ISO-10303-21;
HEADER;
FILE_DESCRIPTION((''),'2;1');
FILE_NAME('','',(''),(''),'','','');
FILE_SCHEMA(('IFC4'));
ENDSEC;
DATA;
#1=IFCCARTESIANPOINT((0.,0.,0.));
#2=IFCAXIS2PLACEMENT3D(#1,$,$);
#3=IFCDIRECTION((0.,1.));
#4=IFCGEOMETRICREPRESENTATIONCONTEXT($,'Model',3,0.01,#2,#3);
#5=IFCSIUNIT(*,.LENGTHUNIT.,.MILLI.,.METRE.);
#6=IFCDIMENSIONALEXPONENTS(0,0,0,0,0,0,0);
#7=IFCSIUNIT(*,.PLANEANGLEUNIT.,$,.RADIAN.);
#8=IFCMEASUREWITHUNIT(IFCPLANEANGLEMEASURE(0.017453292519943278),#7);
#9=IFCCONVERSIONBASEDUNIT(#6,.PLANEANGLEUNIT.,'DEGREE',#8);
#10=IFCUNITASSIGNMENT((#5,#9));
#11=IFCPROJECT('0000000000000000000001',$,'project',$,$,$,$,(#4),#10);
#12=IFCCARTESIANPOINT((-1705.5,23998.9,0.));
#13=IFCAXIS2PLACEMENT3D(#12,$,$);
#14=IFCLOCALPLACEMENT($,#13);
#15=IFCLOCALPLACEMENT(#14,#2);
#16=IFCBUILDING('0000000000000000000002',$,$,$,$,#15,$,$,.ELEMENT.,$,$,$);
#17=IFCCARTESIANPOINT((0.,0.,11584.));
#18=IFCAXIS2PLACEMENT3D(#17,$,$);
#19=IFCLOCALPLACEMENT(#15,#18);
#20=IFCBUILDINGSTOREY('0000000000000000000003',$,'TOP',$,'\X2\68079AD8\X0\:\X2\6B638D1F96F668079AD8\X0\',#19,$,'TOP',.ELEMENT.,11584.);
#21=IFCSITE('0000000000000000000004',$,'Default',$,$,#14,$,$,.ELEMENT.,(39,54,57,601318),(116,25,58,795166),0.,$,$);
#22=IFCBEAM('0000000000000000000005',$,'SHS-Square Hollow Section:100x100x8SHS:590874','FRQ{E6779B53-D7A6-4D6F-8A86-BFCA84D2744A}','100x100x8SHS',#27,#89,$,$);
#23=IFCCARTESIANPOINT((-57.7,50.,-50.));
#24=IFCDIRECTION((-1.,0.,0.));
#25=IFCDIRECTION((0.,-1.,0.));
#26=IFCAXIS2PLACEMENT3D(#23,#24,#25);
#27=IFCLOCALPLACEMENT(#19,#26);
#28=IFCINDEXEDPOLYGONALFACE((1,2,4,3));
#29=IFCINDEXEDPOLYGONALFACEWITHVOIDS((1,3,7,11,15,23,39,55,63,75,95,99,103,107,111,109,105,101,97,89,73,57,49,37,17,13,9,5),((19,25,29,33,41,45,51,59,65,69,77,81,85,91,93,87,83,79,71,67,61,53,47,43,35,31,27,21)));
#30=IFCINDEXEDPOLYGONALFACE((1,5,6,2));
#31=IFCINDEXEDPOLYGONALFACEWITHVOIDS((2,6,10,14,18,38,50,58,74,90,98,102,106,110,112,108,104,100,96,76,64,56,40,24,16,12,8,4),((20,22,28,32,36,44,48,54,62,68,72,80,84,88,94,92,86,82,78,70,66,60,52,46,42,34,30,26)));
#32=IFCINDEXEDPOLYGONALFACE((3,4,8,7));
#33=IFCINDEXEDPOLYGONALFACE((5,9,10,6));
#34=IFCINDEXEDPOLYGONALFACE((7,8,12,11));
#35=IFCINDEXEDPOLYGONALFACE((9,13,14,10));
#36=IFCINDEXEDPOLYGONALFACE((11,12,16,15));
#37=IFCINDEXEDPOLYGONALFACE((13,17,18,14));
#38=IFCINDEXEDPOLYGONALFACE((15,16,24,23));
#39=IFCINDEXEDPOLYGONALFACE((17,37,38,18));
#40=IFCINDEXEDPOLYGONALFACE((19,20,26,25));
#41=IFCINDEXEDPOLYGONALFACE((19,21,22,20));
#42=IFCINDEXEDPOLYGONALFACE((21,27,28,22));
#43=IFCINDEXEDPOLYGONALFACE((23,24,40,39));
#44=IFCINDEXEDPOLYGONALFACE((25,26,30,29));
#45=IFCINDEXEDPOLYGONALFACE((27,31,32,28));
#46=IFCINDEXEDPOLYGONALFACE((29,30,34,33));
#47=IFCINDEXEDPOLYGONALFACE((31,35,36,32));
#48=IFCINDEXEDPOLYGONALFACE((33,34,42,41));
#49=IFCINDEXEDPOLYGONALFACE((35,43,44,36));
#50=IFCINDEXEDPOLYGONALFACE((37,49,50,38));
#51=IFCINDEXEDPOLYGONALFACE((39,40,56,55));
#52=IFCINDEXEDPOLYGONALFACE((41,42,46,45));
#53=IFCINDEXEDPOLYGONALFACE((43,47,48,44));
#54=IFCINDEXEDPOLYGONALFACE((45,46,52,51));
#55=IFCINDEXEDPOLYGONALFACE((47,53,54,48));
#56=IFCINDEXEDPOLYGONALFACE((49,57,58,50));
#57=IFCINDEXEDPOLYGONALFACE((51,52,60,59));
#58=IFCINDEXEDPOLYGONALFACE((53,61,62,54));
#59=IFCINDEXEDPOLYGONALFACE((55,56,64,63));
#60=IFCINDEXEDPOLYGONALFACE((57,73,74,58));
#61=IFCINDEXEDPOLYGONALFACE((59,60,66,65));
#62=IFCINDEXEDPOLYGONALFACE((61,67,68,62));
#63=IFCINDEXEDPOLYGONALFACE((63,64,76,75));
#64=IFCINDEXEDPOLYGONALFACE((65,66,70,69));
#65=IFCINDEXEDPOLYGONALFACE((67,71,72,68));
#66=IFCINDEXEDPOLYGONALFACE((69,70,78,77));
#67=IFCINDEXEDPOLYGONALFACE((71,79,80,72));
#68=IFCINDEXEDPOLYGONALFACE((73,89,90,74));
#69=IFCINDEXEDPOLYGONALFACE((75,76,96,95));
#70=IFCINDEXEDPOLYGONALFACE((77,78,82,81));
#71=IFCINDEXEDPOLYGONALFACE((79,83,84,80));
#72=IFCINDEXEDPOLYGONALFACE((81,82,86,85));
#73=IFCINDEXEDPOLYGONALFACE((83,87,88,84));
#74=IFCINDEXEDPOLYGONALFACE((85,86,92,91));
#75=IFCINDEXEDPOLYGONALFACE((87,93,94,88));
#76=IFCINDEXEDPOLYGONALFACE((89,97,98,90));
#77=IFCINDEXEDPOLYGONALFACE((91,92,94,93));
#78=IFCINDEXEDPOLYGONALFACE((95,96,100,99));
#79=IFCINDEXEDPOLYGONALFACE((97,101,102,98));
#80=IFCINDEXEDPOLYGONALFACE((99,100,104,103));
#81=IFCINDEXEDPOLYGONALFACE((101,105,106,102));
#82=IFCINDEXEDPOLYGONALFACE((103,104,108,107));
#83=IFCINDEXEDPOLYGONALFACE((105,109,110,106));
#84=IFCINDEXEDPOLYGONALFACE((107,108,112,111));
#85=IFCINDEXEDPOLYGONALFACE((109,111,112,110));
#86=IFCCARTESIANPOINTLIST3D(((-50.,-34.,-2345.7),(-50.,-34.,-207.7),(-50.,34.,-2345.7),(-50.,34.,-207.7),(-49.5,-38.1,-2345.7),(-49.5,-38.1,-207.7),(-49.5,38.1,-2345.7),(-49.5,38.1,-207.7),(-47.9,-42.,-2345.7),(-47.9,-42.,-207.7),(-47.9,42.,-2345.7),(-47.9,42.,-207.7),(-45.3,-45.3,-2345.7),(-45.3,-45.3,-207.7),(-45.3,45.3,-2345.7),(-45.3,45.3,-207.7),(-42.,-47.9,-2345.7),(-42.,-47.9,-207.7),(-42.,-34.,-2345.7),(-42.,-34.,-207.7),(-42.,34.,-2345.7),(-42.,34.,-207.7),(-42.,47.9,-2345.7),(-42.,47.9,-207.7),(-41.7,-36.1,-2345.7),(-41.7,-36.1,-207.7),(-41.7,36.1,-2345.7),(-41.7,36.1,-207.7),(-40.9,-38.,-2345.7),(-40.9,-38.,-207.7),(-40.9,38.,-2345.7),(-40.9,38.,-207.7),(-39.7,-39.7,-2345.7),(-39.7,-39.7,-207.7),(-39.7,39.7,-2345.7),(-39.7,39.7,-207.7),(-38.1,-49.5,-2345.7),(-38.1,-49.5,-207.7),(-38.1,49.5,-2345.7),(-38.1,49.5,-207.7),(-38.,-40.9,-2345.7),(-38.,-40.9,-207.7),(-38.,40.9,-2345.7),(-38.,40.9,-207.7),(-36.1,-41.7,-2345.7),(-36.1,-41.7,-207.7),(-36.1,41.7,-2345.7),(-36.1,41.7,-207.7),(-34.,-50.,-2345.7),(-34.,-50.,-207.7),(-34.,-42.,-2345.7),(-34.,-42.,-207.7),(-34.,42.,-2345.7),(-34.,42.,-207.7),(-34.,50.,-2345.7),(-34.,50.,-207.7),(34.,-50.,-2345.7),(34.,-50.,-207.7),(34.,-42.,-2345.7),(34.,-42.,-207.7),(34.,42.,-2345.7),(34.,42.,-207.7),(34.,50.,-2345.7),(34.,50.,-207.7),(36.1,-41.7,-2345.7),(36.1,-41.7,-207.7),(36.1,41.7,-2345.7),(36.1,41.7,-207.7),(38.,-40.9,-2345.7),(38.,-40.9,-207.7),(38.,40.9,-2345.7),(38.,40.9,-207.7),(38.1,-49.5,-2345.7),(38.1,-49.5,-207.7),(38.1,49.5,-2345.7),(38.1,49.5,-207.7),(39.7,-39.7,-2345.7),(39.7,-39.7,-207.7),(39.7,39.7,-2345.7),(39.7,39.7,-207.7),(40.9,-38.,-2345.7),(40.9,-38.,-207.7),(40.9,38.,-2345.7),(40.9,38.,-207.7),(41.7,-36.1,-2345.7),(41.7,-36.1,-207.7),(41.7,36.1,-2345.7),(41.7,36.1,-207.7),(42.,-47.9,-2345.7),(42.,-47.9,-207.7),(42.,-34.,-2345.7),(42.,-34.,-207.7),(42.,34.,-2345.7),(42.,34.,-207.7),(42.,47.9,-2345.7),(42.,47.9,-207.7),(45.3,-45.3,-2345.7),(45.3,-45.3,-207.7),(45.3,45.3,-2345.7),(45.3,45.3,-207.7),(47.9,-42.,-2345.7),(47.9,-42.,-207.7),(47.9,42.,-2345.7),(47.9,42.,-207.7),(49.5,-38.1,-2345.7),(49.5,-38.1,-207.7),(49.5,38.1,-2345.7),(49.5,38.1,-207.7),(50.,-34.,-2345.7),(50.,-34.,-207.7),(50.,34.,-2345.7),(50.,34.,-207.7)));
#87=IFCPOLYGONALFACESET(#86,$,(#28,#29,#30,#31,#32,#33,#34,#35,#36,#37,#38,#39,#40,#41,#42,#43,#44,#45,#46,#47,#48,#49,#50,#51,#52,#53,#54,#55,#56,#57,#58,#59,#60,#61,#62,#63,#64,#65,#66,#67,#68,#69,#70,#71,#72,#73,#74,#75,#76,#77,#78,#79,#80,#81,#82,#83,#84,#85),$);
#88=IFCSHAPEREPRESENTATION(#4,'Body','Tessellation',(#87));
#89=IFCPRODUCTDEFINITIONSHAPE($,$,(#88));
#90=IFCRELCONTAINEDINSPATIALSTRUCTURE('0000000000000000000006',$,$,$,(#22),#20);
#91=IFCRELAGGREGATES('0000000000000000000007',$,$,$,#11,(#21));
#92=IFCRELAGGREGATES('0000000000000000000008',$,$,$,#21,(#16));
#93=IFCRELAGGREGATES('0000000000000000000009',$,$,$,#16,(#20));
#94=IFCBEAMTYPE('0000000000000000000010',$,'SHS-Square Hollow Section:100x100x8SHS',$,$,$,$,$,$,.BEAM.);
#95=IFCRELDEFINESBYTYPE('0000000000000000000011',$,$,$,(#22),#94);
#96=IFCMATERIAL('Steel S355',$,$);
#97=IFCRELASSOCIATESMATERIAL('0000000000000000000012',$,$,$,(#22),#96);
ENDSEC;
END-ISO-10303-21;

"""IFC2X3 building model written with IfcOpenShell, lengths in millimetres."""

from ifc_helpers import new_model, entity, si_unit, converted_unit, direction, frame, origin, origin_2d, place, context, project, spatial, hollow_rectangle, extrude, clip, halfspace, material, type_object, element, save


model = new_model("IFC2X3")

# Units and contexts
model_context = context("Model", 3, precision=0.01, world=origin(), true_north=direction((0.0, 1.0)))
ifc_project = project(units=[si_unit("LENGTHUNIT", "METRE", prefix="MILLI"), converted_unit("PLANEANGLEUNIT", "DEGREE", entity("IfcPlaneAngleMeasure", 0.017453292519943278), si_unit("PLANEANGLEUNIT", "RADIAN"), dimensions=[0, 0, 0, 0, 0, 0, 0])], contexts=[model_context])

# Site, building, storey
site_placement = place(None, frame((-1705.5, 23998.9, 0.0)))
site = spatial("IfcSite", under=ifc_project, at=site_placement, Name="Default", CompositionType="ELEMENT", RefLatitude=(39, 54, 57, 601318), RefLongitude=(116, 25, 58, 795166), RefElevation=0.0)
building_placement = place(site_placement, origin())
building = spatial("IfcBuilding", under=site, at=building_placement, CompositionType="ELEMENT")
storey_placement = place(building_placement, frame((0.0, 0.0, 11584.0)))
storey = spatial("IfcBuildingStorey", under=building, at=storey_placement, Name="TOP", ObjectType="标高:正负零标高", LongName="TOP", CompositionType="ELEMENT", Elevation=11584.0)

# Shared definitions
ifc_material_1 = material(Name="Steel S355")

# Beam
beam_type_1 = type_object("IfcBeamType", Name="SHS-Square Hollow Section:100x100x8SHS", PredefinedType="BEAM")
beam_1_placement = place(storey_placement, frame((-57.7, 50.0, -50.0), z_axis=(-1.0, 0.0, 0.0), x_axis=(0.0, -1.0, 0.0)))
element("IfcBeam", 1, at=beam_1_placement, inside=storey, type_object=beam_type_1, material=ifc_material_1, Name="SHS-Square Hollow Section:100x100x8SHS:590874", Description="FRQ{E6779B53-D7A6-4D6F-8A86-BFCA84D2744A}", ObjectType="100x100x8SHS", context=model_context, shape_type="Clipping", body=[
    clip(clip(extrude(hollow_rectangle(XDim=100.0, YDim=100.0, WallThickness=8.0, InnerFilletRadius=8.0, OuterFilletRadius=16.0, at=origin_2d()), origin(), (0.0, 0.0, -1.0), 2551.4), halfspace(frame((50.0, -11534.0, -207.7), z_axis=(0.0, 0.0, -1.0), x_axis=(-1.0, 0.0, 0.0)), True)), halfspace(frame((50.0, -11534.0, -2345.7), z_axis=(0.0, 0.0, 1.0), x_axis=(1.0, 0.0, 0.0)), True)),
])

save(model, "model.ifc")
